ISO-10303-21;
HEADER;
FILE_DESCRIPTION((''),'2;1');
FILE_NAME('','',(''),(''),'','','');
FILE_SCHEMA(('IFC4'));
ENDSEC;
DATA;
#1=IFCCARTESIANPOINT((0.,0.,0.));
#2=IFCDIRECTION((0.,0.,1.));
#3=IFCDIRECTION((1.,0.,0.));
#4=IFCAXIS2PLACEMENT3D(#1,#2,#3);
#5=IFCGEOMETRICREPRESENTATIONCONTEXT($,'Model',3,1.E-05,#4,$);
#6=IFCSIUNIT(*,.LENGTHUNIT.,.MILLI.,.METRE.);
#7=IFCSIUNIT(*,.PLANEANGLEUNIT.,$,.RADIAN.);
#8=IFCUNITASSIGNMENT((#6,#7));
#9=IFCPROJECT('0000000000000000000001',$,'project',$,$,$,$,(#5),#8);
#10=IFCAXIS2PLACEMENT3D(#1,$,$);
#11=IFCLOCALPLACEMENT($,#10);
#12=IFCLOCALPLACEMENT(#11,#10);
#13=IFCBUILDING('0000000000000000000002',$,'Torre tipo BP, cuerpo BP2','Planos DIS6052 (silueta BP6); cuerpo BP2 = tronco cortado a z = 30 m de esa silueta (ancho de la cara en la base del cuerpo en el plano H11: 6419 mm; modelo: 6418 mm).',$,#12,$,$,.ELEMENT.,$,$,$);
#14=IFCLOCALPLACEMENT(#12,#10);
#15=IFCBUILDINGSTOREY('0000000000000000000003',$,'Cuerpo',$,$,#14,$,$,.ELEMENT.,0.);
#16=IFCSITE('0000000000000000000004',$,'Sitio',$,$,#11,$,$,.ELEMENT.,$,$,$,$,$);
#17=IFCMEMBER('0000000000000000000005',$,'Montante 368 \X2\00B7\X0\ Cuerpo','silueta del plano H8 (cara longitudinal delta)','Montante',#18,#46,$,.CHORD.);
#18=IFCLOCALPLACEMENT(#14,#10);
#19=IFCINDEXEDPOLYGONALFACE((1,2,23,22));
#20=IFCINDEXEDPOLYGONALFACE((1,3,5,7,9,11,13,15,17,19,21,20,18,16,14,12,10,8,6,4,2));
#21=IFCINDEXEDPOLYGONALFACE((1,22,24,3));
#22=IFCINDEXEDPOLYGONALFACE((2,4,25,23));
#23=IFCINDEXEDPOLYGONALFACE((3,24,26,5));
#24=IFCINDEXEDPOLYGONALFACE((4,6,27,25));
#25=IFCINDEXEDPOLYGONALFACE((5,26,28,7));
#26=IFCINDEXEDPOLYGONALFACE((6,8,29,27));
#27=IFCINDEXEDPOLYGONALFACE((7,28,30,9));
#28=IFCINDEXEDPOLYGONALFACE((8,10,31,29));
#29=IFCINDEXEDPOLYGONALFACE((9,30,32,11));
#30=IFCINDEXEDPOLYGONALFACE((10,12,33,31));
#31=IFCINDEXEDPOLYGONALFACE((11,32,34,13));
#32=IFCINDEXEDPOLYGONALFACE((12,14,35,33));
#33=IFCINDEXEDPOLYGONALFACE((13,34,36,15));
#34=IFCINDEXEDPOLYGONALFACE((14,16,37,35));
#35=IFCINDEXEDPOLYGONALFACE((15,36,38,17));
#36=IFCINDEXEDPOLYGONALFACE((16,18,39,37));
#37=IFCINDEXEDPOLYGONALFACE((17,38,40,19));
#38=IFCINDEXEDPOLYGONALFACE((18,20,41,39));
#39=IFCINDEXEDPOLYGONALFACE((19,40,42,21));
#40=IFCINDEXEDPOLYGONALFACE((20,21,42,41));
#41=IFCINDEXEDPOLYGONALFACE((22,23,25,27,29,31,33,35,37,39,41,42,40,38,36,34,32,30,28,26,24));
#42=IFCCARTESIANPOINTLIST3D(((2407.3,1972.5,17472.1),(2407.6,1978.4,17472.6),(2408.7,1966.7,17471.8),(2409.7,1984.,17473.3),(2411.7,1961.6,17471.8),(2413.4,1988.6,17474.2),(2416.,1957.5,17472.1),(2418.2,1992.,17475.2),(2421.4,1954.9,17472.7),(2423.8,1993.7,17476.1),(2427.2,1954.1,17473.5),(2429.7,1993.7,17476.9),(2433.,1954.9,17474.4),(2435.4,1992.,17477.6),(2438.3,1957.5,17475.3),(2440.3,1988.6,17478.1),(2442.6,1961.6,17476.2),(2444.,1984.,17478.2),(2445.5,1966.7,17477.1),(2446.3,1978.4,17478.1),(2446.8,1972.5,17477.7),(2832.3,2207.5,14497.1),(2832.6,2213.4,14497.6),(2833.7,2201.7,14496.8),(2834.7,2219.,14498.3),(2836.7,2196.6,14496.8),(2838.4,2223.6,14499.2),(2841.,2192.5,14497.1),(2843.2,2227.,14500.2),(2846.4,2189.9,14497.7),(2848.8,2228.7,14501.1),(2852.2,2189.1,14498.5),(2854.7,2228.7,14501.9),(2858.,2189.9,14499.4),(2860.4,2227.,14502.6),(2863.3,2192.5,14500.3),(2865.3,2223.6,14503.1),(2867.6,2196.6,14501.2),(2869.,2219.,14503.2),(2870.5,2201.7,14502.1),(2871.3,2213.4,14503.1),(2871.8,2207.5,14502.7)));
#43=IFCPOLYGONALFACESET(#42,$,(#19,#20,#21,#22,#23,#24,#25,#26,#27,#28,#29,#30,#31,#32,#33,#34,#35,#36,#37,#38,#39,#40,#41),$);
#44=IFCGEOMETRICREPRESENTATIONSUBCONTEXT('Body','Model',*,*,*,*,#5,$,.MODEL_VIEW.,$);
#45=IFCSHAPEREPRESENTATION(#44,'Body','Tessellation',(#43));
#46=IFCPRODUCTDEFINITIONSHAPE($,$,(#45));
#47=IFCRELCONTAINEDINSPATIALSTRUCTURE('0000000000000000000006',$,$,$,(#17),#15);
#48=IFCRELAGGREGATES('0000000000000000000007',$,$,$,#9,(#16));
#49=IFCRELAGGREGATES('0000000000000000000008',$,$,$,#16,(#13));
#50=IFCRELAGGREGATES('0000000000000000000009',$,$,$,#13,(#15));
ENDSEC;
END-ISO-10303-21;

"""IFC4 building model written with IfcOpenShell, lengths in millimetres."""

from ifc_helpers import new_model, si_unit, frame, origin, origin_with_axes, place, context, subcontext, project, spatial, circle, extrude, element, save


model = new_model("IFC4")

# Units and contexts
model_context = context("Model", 3, precision=1e-05, world=origin_with_axes())
body_context = subcontext(model_context, "Body", "Model", "MODEL_VIEW")
ifc_project = project(units=[si_unit("LENGTHUNIT", "METRE", prefix="MILLI"), si_unit("PLANEANGLEUNIT", "RADIAN")], contexts=[model_context])

# Site, building, storey
site_placement = place(None, origin())
site = spatial("IfcSite", under=ifc_project, at=site_placement, Name="Sitio", CompositionType="ELEMENT")
building_placement = place(site_placement, origin())
building = spatial("IfcBuilding", under=site, at=building_placement, Name="Torre tipo BP, cuerpo BP2", Description="Planos DIS6052 (silueta BP6); cuerpo BP2 = tronco cortado a z = 30 m de esa silueta (ancho de la cara en la base del cuerpo en el plano H11: 6419 mm; modelo: 6418 mm).", CompositionType="ELEMENT")
storey_placement = place(building_placement, origin())
storey = spatial("IfcBuildingStorey", under=building, at=storey_placement, Name="Cuerpo", CompositionType="ELEMENT", Elevation=0.0)

# Member
member_placement = place(storey_placement, frame((2427.0, 1974.0, 17475.0), z_axis=(0.140991, 0.07796, -0.986937), x_axis=(0.011025, -0.996957, -0.077176)))
element("IfcMember", 1, at=member_placement, inside=storey, Name="Montante 368 · Cuerpo", Description="silueta del plano H8 (cara longitudinal delta)", ObjectType="Montante", PredefinedType="CHORD", context=body_context, shape_type="SweptSolid", body=[
    extrude(circle(Radius=20.0), None, (0.0, 0.0, 1.0), 3014.4),
])

save(model, "model.ifc")
